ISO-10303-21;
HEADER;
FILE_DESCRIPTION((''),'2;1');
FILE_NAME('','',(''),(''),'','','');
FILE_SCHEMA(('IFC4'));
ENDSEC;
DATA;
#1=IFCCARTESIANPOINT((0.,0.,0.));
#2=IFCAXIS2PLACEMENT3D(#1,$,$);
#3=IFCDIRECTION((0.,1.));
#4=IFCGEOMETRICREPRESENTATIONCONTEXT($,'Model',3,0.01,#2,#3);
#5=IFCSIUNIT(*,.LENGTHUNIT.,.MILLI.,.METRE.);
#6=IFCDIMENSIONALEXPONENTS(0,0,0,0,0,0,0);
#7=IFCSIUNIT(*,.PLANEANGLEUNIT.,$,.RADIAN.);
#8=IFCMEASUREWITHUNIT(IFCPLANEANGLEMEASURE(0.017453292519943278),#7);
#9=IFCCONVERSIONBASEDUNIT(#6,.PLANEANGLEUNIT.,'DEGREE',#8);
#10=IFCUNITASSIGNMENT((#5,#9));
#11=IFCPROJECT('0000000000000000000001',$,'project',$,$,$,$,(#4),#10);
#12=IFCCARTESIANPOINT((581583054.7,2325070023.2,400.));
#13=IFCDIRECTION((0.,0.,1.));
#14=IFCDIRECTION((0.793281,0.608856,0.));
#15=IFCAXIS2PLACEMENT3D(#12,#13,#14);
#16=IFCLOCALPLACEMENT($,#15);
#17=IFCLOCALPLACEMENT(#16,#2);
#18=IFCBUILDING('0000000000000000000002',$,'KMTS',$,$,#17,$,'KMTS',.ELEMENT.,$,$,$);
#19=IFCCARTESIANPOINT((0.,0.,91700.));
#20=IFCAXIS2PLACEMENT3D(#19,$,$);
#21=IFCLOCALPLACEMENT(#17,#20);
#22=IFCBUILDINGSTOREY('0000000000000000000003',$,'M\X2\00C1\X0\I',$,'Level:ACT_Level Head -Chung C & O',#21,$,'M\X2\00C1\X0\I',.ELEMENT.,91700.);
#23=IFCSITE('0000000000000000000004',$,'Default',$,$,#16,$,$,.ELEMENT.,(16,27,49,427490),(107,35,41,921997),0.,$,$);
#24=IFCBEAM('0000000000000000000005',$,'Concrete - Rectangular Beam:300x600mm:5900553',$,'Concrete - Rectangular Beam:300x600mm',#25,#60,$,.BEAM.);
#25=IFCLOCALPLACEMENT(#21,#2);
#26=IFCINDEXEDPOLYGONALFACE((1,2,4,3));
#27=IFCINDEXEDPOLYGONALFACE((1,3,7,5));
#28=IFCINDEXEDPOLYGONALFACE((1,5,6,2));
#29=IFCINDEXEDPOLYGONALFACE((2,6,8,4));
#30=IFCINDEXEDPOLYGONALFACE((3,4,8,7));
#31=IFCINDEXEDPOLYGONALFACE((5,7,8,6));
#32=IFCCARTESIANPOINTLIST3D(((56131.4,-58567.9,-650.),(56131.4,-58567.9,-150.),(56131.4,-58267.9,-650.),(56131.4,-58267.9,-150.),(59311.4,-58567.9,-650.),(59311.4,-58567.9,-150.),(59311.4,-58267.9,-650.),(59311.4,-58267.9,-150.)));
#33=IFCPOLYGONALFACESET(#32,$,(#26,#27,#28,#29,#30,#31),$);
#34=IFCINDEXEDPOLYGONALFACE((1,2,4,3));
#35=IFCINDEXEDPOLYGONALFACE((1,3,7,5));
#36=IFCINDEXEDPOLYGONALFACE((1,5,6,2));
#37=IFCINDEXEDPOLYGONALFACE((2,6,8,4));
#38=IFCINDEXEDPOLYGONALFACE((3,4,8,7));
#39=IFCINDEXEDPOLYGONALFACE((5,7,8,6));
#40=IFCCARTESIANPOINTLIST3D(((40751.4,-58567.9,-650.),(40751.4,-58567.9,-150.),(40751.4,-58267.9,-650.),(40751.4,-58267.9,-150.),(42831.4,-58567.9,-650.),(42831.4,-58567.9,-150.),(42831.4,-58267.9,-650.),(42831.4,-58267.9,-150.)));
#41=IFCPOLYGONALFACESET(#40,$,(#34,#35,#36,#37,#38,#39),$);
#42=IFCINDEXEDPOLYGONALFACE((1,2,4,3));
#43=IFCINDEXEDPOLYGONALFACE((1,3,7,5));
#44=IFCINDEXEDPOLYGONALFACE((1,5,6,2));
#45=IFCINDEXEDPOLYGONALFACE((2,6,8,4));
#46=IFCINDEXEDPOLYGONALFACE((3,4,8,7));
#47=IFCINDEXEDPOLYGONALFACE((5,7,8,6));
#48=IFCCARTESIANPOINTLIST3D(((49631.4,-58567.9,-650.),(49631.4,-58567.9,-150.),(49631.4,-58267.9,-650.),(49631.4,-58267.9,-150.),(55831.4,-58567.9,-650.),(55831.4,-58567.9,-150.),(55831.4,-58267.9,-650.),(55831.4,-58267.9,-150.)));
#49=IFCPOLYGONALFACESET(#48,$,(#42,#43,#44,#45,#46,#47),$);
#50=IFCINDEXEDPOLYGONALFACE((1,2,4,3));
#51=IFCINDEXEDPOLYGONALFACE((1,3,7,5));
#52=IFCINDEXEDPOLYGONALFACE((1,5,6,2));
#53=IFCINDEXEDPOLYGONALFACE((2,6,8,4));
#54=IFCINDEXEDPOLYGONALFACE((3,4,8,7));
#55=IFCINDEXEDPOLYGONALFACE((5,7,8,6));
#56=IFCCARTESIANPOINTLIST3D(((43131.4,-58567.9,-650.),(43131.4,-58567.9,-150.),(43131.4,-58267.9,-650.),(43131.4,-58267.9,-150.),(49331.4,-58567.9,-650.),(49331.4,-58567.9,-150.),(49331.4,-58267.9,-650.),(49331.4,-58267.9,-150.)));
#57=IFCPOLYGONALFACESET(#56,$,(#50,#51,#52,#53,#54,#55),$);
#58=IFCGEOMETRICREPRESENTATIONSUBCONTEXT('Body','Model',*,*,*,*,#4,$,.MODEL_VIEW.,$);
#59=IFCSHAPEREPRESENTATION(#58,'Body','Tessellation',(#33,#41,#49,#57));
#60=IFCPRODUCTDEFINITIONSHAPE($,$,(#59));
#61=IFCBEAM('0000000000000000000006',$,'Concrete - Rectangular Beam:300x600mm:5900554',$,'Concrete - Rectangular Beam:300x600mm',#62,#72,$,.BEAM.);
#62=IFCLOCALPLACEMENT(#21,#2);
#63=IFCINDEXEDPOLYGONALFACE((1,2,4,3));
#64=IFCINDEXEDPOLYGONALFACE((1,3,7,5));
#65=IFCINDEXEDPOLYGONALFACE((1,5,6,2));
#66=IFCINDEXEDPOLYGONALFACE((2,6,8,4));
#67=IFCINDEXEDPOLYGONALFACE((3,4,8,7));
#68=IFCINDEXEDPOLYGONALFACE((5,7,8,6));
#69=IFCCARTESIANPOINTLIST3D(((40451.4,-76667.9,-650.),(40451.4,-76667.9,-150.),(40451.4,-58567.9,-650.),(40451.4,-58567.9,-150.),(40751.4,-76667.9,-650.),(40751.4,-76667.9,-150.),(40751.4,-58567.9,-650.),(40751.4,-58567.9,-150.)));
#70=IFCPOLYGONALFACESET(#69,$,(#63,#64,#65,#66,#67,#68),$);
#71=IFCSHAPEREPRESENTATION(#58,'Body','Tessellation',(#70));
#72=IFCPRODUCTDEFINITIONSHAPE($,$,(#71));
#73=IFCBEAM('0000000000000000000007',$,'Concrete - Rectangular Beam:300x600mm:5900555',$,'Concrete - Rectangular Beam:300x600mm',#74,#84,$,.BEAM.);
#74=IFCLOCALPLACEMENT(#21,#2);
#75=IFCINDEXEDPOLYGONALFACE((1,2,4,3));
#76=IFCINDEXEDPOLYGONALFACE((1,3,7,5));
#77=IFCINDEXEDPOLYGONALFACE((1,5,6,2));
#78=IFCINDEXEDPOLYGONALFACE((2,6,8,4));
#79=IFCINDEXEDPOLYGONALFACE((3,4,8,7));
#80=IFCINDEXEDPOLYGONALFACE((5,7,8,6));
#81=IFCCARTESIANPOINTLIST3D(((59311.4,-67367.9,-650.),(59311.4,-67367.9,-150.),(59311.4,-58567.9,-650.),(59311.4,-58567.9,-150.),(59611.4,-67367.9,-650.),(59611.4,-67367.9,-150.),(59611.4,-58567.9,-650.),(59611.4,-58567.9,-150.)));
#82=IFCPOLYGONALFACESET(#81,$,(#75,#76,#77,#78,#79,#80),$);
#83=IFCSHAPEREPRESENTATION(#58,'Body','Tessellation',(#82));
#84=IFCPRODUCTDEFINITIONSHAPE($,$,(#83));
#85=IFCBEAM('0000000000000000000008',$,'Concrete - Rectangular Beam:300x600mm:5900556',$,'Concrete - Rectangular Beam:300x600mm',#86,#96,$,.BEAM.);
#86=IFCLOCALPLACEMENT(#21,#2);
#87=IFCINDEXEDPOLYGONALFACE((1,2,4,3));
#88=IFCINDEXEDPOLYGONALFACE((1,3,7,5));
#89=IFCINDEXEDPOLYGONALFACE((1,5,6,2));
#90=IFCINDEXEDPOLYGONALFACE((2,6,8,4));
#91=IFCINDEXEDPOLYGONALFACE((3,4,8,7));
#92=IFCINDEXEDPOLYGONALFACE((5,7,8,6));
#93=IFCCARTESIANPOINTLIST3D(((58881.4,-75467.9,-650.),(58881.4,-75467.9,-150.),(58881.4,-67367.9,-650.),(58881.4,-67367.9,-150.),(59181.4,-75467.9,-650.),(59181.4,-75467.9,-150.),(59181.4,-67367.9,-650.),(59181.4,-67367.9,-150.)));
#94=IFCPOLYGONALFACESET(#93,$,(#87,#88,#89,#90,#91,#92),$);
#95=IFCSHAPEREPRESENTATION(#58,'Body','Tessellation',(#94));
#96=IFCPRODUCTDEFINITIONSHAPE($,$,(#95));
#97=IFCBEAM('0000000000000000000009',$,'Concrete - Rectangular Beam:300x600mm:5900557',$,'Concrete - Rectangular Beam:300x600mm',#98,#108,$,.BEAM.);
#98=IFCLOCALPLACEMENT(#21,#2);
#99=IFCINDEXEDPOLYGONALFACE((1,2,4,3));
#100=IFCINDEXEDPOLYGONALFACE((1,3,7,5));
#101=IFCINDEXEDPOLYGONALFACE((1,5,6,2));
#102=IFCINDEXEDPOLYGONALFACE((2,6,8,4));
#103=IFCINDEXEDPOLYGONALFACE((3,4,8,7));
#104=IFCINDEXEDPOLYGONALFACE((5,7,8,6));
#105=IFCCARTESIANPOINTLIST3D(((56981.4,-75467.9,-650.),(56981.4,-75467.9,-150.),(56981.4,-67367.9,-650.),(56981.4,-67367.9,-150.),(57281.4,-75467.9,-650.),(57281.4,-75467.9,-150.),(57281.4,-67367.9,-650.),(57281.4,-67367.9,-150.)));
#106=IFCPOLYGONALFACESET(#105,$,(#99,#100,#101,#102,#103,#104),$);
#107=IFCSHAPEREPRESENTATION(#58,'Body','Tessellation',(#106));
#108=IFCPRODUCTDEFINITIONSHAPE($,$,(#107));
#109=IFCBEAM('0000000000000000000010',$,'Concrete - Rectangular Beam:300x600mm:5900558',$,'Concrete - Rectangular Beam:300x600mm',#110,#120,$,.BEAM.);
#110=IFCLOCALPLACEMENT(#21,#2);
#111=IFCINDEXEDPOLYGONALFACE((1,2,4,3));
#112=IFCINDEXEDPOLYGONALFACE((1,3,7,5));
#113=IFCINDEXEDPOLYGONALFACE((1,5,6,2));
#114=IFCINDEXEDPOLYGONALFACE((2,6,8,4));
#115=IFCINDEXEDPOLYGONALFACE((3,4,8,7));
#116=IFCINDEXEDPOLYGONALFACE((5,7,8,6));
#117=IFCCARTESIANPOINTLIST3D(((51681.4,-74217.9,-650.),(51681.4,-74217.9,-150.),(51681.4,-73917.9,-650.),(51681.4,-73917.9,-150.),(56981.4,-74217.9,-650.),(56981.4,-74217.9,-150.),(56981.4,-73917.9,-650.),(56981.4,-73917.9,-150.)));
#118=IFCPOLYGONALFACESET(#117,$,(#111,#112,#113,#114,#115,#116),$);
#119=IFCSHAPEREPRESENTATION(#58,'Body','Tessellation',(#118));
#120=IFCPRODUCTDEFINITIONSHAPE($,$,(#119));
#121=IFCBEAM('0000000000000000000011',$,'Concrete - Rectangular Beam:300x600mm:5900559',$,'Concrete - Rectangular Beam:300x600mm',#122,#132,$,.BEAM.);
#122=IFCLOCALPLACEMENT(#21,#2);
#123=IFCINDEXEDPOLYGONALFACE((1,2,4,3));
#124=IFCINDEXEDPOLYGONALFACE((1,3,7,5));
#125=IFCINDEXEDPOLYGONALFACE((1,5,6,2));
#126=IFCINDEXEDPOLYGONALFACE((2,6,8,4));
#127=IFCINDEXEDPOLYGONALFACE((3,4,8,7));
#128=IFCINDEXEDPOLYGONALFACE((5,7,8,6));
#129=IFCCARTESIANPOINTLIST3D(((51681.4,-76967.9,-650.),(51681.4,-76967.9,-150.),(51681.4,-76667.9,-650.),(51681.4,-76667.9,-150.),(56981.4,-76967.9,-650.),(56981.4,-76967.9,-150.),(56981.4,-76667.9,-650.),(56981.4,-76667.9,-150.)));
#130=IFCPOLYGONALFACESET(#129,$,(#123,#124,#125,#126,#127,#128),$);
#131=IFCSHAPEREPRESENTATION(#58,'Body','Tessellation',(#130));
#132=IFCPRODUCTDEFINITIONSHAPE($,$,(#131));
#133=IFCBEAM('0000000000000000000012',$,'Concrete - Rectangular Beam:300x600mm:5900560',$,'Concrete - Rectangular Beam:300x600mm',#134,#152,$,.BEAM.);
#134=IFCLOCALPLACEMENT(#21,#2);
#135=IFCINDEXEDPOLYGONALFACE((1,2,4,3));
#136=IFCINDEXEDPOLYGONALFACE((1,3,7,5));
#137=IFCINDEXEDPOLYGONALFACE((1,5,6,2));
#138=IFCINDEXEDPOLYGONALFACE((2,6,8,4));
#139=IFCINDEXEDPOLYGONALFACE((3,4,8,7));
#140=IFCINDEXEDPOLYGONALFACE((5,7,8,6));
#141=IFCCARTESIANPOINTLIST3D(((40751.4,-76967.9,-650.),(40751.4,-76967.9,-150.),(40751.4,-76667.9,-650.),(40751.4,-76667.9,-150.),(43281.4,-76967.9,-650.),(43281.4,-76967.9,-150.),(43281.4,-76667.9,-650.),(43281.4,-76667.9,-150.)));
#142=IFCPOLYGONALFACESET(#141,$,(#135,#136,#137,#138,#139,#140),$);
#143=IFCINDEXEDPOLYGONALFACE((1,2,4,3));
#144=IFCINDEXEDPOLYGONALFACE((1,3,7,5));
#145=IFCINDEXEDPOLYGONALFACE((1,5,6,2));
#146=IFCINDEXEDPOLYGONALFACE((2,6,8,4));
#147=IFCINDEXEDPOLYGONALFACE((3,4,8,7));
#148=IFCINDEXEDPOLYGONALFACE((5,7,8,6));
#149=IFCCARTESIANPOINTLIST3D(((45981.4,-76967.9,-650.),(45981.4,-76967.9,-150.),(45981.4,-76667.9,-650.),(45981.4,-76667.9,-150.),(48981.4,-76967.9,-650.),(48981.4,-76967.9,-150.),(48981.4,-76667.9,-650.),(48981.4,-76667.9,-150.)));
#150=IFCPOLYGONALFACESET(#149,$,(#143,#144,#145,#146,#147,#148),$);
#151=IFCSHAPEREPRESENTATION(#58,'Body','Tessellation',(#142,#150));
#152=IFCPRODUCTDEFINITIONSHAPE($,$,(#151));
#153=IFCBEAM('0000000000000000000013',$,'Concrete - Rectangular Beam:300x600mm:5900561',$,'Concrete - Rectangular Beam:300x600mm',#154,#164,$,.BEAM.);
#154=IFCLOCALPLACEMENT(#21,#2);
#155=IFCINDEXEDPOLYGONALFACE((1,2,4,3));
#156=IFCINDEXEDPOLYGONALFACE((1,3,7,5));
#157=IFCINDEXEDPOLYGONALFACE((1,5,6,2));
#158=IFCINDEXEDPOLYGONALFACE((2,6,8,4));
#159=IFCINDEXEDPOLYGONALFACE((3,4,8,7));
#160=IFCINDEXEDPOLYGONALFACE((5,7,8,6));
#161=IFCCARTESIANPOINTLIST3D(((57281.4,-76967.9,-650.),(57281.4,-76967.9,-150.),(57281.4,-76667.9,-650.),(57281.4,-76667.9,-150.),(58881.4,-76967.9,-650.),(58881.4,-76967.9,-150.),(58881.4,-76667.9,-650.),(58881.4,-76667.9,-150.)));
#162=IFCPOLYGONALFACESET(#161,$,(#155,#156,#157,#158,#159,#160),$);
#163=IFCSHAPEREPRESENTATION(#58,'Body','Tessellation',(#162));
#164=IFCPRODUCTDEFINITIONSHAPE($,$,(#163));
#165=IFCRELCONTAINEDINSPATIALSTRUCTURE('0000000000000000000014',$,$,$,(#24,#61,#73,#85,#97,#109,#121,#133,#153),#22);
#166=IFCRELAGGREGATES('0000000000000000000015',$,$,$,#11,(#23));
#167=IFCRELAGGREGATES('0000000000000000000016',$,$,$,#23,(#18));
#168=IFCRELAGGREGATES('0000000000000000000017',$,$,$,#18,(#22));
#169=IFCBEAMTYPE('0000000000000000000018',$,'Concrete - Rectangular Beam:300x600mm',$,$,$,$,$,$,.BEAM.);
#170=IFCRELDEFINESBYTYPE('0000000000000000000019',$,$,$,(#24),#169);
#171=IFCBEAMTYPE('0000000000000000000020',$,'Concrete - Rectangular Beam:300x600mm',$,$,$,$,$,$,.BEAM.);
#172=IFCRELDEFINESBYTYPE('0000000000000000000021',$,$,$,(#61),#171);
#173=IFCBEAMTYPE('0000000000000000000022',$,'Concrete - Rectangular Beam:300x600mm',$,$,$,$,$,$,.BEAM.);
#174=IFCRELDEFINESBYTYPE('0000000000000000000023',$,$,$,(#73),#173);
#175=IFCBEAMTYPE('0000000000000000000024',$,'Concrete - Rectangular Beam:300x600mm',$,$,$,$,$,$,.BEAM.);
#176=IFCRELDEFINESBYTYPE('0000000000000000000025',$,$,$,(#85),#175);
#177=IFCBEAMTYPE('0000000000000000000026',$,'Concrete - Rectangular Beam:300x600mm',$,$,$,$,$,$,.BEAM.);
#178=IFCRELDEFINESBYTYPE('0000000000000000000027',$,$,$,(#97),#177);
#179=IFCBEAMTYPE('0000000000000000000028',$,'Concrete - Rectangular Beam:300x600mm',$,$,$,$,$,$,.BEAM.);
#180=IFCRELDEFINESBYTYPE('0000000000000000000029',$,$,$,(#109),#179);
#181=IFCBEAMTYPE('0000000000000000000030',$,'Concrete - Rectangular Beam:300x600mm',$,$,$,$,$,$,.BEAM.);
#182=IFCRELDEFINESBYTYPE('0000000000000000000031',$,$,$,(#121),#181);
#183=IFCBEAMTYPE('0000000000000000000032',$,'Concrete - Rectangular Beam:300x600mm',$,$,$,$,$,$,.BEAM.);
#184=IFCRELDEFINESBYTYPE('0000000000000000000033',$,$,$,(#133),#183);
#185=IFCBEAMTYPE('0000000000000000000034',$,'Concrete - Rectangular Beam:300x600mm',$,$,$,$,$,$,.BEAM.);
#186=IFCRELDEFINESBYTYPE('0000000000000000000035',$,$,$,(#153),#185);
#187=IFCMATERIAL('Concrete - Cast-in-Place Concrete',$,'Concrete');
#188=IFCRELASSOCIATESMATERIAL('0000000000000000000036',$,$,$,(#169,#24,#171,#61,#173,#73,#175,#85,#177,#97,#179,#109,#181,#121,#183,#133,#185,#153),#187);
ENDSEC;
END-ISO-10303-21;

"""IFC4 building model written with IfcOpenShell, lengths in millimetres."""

from ifc_helpers import new_model, entity, si_unit, converted_unit, direction, frame, origin, place, context, subcontext, project, spatial, indexed_curve, outline, extrude, source, transform, mapped, material, type_object, type_shapes, element, save


model = new_model("IFC4")

# Units and contexts
model_context = context("Model", 3, precision=0.01, world=origin(), true_north=direction((0.0, 1.0)))
body_context = subcontext(model_context, "Body", "Model", "MODEL_VIEW")
ifc_project = project(units=[si_unit("LENGTHUNIT", "METRE", prefix="MILLI"), converted_unit("PLANEANGLEUNIT", "DEGREE", entity("IfcPlaneAngleMeasure", 0.017453292519943278), si_unit("PLANEANGLEUNIT", "RADIAN"), dimensions=[0, 0, 0, 0, 0, 0, 0])], contexts=[model_context])

# Site, building, storey
site_placement = place(None, frame((581583054.7, 2325070023.2, 400.0), z_axis=(0.0, 0.0, 1.0), x_axis=(0.793281, 0.608856, 0.0)))
site = spatial("IfcSite", under=ifc_project, at=site_placement, Name="Default", CompositionType="ELEMENT", RefLatitude=(16, 27, 49, 427490), RefLongitude=(107, 35, 41, 921997), RefElevation=0.0)
building_placement = place(site_placement, origin())
building = spatial("IfcBuilding", under=site, at=building_placement, Name="KMTS", LongName="KMTS", CompositionType="ELEMENT")
storey_placement = place(building_placement, frame((0.0, 0.0, 91700.0)))
storey = spatial("IfcBuildingStorey", under=building, at=storey_placement, Name="MÁI", ObjectType="Level:ACT_Level Head -Chung C & O", LongName="MÁI", CompositionType="ELEMENT", Elevation=91700.0)

# Beams
ifc_material_1 = material(Name="Concrete - Cast-in-Place Concrete", Category="Concrete")
beam_type_1 = type_object("IfcBeamType", Name="Concrete - Rectangular Beam:300x600mm", PredefinedType="BEAM", material=ifc_material_1)
shared_shape_1 = source(origin(), body_context, "Body", "SweptSolid", [
    extrude(outline(indexed_curve([(-250.0, -150.0), (250.0, -150.0), (250.0, 150.0), (-250.0, 150.0), (-250.0, -150.0)], self_intersect=False)), frame((56131.4, -58417.9, 91300.0), z_axis=(1.0, 0.0, 0.0), x_axis=(0.0, 0.0, -1.0)), (0.0, 0.0, 1.0), 3180.0),
    extrude(outline(indexed_curve([(-250.0, -150.0), (250.0, -150.0), (250.0, 150.0), (-250.0, 150.0), (-250.0, -150.0)], self_intersect=False)), frame((40751.4, -58417.9, 91300.0), z_axis=(1.0, 0.0, 0.0), x_axis=(0.0, 0.0, -1.0)), (0.0, 0.0, 1.0), 2080.0),
    extrude(outline(indexed_curve([(-250.0, -150.0), (250.0, -150.0), (250.0, 150.0), (-250.0, 150.0), (-250.0, -150.0)], self_intersect=False)), frame((49631.4, -58417.9, 91300.0), z_axis=(1.0, 0.0, 0.0), x_axis=(0.0, 0.0, -1.0)), (0.0, 0.0, 1.0), 6200.0),
    extrude(outline(indexed_curve([(-250.0, -150.0), (250.0, -150.0), (250.0, 150.0), (-250.0, 150.0), (-250.0, -150.0)], self_intersect=False)), frame((43131.4, -58417.9, 91300.0), z_axis=(1.0, 0.0, 0.0), x_axis=(0.0, 0.0, -1.0)), (0.0, 0.0, 1.0), 6200.0),
])
type_shapes(beam_type_1, [shared_shape_1])
beam_1_placement = place(storey_placement, frame((0.0, 0.0, -91700.0)))
element("IfcBeam", 1, at=beam_1_placement, inside=storey, type_object=beam_type_1, material=ifc_material_1, Name="Concrete - Rectangular Beam:300x600mm:5900553", ObjectType="Concrete - Rectangular Beam:300x600mm", PredefinedType="BEAM", context=body_context, shape_type="MappedRepresentation", body=[
    mapped(shared_shape_1, transform((0.0, 0.0, 0.0), scale=1.0)),
])
beam_type_2 = type_object("IfcBeamType", Name="Concrete - Rectangular Beam:300x600mm", PredefinedType="BEAM", material=ifc_material_1)
shared_shape_2 = source(origin(), body_context, "Body", "SweptSolid", [
    extrude(outline(indexed_curve([(-150.0, -250.0), (150.0, -250.0), (150.0, 250.0), (-150.0, 250.0), (-150.0, -250.0)], self_intersect=False)), frame((40601.4, -76667.9, 91300.0), z_axis=(0.0, 1.0, 0.0), x_axis=(-1.0, 0.0, 0.0)), (0.0, 0.0, 1.0), 18100.0),
])
type_shapes(beam_type_2, [shared_shape_2])
beam_2_placement = place(storey_placement, frame((0.0, 0.0, -91700.0)))
element("IfcBeam", 2, at=beam_2_placement, inside=storey, type_object=beam_type_2, material=ifc_material_1, Name="Concrete - Rectangular Beam:300x600mm:5900554", ObjectType="Concrete - Rectangular Beam:300x600mm", PredefinedType="BEAM", context=body_context, shape_type="MappedRepresentation", body=[
    mapped(shared_shape_2, transform((0.0, 0.0, 0.0), scale=1.0)),
])
beam_type_3 = type_object("IfcBeamType", Name="Concrete - Rectangular Beam:300x600mm", PredefinedType="BEAM", material=ifc_material_1)
shared_shape_3 = source(origin(), body_context, "Body", "SweptSolid", [
    extrude(outline(indexed_curve([(-150.0, -250.0), (150.0, -250.0), (150.0, 250.0), (-150.0, 250.0), (-150.0, -250.0)], self_intersect=False)), frame((59461.4, -58567.9, 91300.0), z_axis=(0.0, -1.0, 0.0), x_axis=(-1.0, 0.0, 0.0)), (0.0, 0.0, 1.0), 8800.0),
])
type_shapes(beam_type_3, [shared_shape_3])
beam_3_placement = place(storey_placement, frame((0.0, 0.0, -91700.0)))
element("IfcBeam", 3, at=beam_3_placement, inside=storey, type_object=beam_type_3, material=ifc_material_1, Name="Concrete - Rectangular Beam:300x600mm:5900555", ObjectType="Concrete - Rectangular Beam:300x600mm", PredefinedType="BEAM", context=body_context, shape_type="MappedRepresentation", body=[
    mapped(shared_shape_3, transform((0.0, 0.0, 0.0), scale=1.0)),
])
beam_type_4 = type_object("IfcBeamType", Name="Concrete - Rectangular Beam:300x600mm", PredefinedType="BEAM", material=ifc_material_1)
shared_shape_4 = source(origin(), body_context, "Body", "SweptSolid", [
    extrude(outline(indexed_curve([(-150.0, -250.0), (150.0, -250.0), (150.0, 250.0), (-150.0, 250.0), (-150.0, -250.0)], self_intersect=False)), frame((59031.4, -67367.9, 91300.0), z_axis=(0.0, -1.0, 0.0), x_axis=(-1.0, 0.0, 0.0)), (0.0, 0.0, 1.0), 8100.0),
])
type_shapes(beam_type_4, [shared_shape_4])
beam_4_placement = place(storey_placement, frame((0.0, 0.0, -91700.0)))
element("IfcBeam", 4, at=beam_4_placement, inside=storey, type_object=beam_type_4, material=ifc_material_1, Name="Concrete - Rectangular Beam:300x600mm:5900556", ObjectType="Concrete - Rectangular Beam:300x600mm", PredefinedType="BEAM", context=body_context, shape_type="MappedRepresentation", body=[
    mapped(shared_shape_4, transform((0.0, 0.0, 0.0), scale=1.0)),
])
beam_type_5 = type_object("IfcBeamType", Name="Concrete - Rectangular Beam:300x600mm", PredefinedType="BEAM", material=ifc_material_1)
shared_shape_5 = source(origin(), body_context, "Body", "SweptSolid", [
    extrude(outline(indexed_curve([(-150.0, -250.0), (150.0, -250.0), (150.0, 250.0), (-150.0, 250.0), (-150.0, -250.0)], self_intersect=False)), frame((57131.4, -67367.9, 91300.0), z_axis=(0.0, -1.0, 0.0), x_axis=(-1.0, 0.0, 0.0)), (0.0, 0.0, 1.0), 8100.0),
])
type_shapes(beam_type_5, [shared_shape_5])
beam_5_placement = place(storey_placement, frame((0.0, 0.0, -91700.0)))
element("IfcBeam", 5, at=beam_5_placement, inside=storey, type_object=beam_type_5, material=ifc_material_1, Name="Concrete - Rectangular Beam:300x600mm:5900557", ObjectType="Concrete - Rectangular Beam:300x600mm", PredefinedType="BEAM", context=body_context, shape_type="MappedRepresentation", body=[
    mapped(shared_shape_5, transform((0.0, 0.0, 0.0), scale=1.0)),
])
beam_type_6 = type_object("IfcBeamType", Name="Concrete - Rectangular Beam:300x600mm", PredefinedType="BEAM", material=ifc_material_1)
shared_shape_6 = source(origin(), body_context, "Body", "SweptSolid", [
    extrude(outline(indexed_curve([(-250.0, -150.0), (250.0, -150.0), (250.0, 150.0), (-250.0, 150.0), (-250.0, -150.0)], self_intersect=False)), frame((51681.4, -74067.9, 91300.0), z_axis=(1.0, 0.0, 0.0), x_axis=(0.0, 0.0, -1.0)), (0.0, 0.0, 1.0), 5300.0),
])
type_shapes(beam_type_6, [shared_shape_6])
beam_6_placement = place(storey_placement, frame((0.0, 0.0, -91700.0)))
element("IfcBeam", 6, at=beam_6_placement, inside=storey, type_object=beam_type_6, material=ifc_material_1, Name="Concrete - Rectangular Beam:300x600mm:5900558", ObjectType="Concrete - Rectangular Beam:300x600mm", PredefinedType="BEAM", context=body_context, shape_type="MappedRepresentation", body=[
    mapped(shared_shape_6, transform((0.0, 0.0, 0.0), scale=1.0)),
])
beam_type_7 = type_object("IfcBeamType", Name="Concrete - Rectangular Beam:300x600mm", PredefinedType="BEAM", material=ifc_material_1)
shared_shape_7 = source(origin(), body_context, "Body", "SweptSolid", [
    extrude(outline(indexed_curve([(-250.0, -150.0), (250.0, -150.0), (250.0, 150.0), (-250.0, 150.0), (-250.0, -150.0)], self_intersect=False)), frame((51681.4, -76817.9, 91300.0), z_axis=(1.0, 0.0, 0.0), x_axis=(0.0, 0.0, -1.0)), (0.0, 0.0, 1.0), 5300.0),
])
type_shapes(beam_type_7, [shared_shape_7])
beam_7_placement = place(storey_placement, frame((0.0, 0.0, -91700.0)))
element("IfcBeam", 7, at=beam_7_placement, inside=storey, type_object=beam_type_7, material=ifc_material_1, Name="Concrete - Rectangular Beam:300x600mm:5900559", ObjectType="Concrete - Rectangular Beam:300x600mm", PredefinedType="BEAM", context=body_context, shape_type="MappedRepresentation", body=[
    mapped(shared_shape_7, transform((0.0, 0.0, 0.0), scale=1.0)),
])
beam_type_8 = type_object("IfcBeamType", Name="Concrete - Rectangular Beam:300x600mm", PredefinedType="BEAM", material=ifc_material_1)
shared_shape_8 = source(origin(), body_context, "Body", "SweptSolid", [
    extrude(outline(indexed_curve([(-250.0, -150.0), (250.0, -150.0), (250.0, 150.0), (-250.0, 150.0), (-250.0, -150.0)], self_intersect=False)), frame((43281.4, -76817.9, 91300.0), z_axis=(-1.0, 0.0, 0.0), x_axis=(0.0, 0.0, -1.0)), (0.0, 0.0, 1.0), 2530.0),
    extrude(outline(indexed_curve([(-250.0, -150.0), (250.0, -150.0), (250.0, 150.0), (-250.0, 150.0), (-250.0, -150.0)], self_intersect=False)), frame((48981.4, -76817.9, 91300.0), z_axis=(-1.0, 0.0, 0.0), x_axis=(0.0, 0.0, -1.0)), (0.0, 0.0, 1.0), 3000.0),
])
type_shapes(beam_type_8, [shared_shape_8])
beam_8_placement = place(storey_placement, frame((0.0, 0.0, -91700.0)))
element("IfcBeam", 8, at=beam_8_placement, inside=storey, type_object=beam_type_8, material=ifc_material_1, Name="Concrete - Rectangular Beam:300x600mm:5900560", ObjectType="Concrete - Rectangular Beam:300x600mm", PredefinedType="BEAM", context=body_context, shape_type="MappedRepresentation", body=[
    mapped(shared_shape_8, transform((0.0, 0.0, 0.0), scale=1.0)),
])
beam_type_9 = type_object("IfcBeamType", Name="Concrete - Rectangular Beam:300x600mm", PredefinedType="BEAM", material=ifc_material_1)
shared_shape_9 = source(origin(), body_context, "Body", "SweptSolid", [
    extrude(outline(indexed_curve([(-250.0, -150.0), (250.0, -150.0), (250.0, 150.0), (-250.0, 150.0), (-250.0, -150.0)], self_intersect=False)), frame((58881.4, -76817.9, 91300.0), z_axis=(-1.0, 0.0, 0.0), x_axis=(0.0, 0.0, -1.0)), (0.0, 0.0, 1.0), 1600.0),
])
type_shapes(beam_type_9, [shared_shape_9])
beam_9_placement = place(storey_placement, frame((0.0, 0.0, -91700.0)))
element("IfcBeam", 9, at=beam_9_placement, inside=storey, type_object=beam_type_9, material=ifc_material_1, Name="Concrete - Rectangular Beam:300x600mm:5900561", ObjectType="Concrete - Rectangular Beam:300x600mm", PredefinedType="BEAM", context=body_context, shape_type="MappedRepresentation", body=[
    mapped(shared_shape_9, transform((0.0, 0.0, 0.0), scale=1.0)),
])

save(model, "model.ifc")
